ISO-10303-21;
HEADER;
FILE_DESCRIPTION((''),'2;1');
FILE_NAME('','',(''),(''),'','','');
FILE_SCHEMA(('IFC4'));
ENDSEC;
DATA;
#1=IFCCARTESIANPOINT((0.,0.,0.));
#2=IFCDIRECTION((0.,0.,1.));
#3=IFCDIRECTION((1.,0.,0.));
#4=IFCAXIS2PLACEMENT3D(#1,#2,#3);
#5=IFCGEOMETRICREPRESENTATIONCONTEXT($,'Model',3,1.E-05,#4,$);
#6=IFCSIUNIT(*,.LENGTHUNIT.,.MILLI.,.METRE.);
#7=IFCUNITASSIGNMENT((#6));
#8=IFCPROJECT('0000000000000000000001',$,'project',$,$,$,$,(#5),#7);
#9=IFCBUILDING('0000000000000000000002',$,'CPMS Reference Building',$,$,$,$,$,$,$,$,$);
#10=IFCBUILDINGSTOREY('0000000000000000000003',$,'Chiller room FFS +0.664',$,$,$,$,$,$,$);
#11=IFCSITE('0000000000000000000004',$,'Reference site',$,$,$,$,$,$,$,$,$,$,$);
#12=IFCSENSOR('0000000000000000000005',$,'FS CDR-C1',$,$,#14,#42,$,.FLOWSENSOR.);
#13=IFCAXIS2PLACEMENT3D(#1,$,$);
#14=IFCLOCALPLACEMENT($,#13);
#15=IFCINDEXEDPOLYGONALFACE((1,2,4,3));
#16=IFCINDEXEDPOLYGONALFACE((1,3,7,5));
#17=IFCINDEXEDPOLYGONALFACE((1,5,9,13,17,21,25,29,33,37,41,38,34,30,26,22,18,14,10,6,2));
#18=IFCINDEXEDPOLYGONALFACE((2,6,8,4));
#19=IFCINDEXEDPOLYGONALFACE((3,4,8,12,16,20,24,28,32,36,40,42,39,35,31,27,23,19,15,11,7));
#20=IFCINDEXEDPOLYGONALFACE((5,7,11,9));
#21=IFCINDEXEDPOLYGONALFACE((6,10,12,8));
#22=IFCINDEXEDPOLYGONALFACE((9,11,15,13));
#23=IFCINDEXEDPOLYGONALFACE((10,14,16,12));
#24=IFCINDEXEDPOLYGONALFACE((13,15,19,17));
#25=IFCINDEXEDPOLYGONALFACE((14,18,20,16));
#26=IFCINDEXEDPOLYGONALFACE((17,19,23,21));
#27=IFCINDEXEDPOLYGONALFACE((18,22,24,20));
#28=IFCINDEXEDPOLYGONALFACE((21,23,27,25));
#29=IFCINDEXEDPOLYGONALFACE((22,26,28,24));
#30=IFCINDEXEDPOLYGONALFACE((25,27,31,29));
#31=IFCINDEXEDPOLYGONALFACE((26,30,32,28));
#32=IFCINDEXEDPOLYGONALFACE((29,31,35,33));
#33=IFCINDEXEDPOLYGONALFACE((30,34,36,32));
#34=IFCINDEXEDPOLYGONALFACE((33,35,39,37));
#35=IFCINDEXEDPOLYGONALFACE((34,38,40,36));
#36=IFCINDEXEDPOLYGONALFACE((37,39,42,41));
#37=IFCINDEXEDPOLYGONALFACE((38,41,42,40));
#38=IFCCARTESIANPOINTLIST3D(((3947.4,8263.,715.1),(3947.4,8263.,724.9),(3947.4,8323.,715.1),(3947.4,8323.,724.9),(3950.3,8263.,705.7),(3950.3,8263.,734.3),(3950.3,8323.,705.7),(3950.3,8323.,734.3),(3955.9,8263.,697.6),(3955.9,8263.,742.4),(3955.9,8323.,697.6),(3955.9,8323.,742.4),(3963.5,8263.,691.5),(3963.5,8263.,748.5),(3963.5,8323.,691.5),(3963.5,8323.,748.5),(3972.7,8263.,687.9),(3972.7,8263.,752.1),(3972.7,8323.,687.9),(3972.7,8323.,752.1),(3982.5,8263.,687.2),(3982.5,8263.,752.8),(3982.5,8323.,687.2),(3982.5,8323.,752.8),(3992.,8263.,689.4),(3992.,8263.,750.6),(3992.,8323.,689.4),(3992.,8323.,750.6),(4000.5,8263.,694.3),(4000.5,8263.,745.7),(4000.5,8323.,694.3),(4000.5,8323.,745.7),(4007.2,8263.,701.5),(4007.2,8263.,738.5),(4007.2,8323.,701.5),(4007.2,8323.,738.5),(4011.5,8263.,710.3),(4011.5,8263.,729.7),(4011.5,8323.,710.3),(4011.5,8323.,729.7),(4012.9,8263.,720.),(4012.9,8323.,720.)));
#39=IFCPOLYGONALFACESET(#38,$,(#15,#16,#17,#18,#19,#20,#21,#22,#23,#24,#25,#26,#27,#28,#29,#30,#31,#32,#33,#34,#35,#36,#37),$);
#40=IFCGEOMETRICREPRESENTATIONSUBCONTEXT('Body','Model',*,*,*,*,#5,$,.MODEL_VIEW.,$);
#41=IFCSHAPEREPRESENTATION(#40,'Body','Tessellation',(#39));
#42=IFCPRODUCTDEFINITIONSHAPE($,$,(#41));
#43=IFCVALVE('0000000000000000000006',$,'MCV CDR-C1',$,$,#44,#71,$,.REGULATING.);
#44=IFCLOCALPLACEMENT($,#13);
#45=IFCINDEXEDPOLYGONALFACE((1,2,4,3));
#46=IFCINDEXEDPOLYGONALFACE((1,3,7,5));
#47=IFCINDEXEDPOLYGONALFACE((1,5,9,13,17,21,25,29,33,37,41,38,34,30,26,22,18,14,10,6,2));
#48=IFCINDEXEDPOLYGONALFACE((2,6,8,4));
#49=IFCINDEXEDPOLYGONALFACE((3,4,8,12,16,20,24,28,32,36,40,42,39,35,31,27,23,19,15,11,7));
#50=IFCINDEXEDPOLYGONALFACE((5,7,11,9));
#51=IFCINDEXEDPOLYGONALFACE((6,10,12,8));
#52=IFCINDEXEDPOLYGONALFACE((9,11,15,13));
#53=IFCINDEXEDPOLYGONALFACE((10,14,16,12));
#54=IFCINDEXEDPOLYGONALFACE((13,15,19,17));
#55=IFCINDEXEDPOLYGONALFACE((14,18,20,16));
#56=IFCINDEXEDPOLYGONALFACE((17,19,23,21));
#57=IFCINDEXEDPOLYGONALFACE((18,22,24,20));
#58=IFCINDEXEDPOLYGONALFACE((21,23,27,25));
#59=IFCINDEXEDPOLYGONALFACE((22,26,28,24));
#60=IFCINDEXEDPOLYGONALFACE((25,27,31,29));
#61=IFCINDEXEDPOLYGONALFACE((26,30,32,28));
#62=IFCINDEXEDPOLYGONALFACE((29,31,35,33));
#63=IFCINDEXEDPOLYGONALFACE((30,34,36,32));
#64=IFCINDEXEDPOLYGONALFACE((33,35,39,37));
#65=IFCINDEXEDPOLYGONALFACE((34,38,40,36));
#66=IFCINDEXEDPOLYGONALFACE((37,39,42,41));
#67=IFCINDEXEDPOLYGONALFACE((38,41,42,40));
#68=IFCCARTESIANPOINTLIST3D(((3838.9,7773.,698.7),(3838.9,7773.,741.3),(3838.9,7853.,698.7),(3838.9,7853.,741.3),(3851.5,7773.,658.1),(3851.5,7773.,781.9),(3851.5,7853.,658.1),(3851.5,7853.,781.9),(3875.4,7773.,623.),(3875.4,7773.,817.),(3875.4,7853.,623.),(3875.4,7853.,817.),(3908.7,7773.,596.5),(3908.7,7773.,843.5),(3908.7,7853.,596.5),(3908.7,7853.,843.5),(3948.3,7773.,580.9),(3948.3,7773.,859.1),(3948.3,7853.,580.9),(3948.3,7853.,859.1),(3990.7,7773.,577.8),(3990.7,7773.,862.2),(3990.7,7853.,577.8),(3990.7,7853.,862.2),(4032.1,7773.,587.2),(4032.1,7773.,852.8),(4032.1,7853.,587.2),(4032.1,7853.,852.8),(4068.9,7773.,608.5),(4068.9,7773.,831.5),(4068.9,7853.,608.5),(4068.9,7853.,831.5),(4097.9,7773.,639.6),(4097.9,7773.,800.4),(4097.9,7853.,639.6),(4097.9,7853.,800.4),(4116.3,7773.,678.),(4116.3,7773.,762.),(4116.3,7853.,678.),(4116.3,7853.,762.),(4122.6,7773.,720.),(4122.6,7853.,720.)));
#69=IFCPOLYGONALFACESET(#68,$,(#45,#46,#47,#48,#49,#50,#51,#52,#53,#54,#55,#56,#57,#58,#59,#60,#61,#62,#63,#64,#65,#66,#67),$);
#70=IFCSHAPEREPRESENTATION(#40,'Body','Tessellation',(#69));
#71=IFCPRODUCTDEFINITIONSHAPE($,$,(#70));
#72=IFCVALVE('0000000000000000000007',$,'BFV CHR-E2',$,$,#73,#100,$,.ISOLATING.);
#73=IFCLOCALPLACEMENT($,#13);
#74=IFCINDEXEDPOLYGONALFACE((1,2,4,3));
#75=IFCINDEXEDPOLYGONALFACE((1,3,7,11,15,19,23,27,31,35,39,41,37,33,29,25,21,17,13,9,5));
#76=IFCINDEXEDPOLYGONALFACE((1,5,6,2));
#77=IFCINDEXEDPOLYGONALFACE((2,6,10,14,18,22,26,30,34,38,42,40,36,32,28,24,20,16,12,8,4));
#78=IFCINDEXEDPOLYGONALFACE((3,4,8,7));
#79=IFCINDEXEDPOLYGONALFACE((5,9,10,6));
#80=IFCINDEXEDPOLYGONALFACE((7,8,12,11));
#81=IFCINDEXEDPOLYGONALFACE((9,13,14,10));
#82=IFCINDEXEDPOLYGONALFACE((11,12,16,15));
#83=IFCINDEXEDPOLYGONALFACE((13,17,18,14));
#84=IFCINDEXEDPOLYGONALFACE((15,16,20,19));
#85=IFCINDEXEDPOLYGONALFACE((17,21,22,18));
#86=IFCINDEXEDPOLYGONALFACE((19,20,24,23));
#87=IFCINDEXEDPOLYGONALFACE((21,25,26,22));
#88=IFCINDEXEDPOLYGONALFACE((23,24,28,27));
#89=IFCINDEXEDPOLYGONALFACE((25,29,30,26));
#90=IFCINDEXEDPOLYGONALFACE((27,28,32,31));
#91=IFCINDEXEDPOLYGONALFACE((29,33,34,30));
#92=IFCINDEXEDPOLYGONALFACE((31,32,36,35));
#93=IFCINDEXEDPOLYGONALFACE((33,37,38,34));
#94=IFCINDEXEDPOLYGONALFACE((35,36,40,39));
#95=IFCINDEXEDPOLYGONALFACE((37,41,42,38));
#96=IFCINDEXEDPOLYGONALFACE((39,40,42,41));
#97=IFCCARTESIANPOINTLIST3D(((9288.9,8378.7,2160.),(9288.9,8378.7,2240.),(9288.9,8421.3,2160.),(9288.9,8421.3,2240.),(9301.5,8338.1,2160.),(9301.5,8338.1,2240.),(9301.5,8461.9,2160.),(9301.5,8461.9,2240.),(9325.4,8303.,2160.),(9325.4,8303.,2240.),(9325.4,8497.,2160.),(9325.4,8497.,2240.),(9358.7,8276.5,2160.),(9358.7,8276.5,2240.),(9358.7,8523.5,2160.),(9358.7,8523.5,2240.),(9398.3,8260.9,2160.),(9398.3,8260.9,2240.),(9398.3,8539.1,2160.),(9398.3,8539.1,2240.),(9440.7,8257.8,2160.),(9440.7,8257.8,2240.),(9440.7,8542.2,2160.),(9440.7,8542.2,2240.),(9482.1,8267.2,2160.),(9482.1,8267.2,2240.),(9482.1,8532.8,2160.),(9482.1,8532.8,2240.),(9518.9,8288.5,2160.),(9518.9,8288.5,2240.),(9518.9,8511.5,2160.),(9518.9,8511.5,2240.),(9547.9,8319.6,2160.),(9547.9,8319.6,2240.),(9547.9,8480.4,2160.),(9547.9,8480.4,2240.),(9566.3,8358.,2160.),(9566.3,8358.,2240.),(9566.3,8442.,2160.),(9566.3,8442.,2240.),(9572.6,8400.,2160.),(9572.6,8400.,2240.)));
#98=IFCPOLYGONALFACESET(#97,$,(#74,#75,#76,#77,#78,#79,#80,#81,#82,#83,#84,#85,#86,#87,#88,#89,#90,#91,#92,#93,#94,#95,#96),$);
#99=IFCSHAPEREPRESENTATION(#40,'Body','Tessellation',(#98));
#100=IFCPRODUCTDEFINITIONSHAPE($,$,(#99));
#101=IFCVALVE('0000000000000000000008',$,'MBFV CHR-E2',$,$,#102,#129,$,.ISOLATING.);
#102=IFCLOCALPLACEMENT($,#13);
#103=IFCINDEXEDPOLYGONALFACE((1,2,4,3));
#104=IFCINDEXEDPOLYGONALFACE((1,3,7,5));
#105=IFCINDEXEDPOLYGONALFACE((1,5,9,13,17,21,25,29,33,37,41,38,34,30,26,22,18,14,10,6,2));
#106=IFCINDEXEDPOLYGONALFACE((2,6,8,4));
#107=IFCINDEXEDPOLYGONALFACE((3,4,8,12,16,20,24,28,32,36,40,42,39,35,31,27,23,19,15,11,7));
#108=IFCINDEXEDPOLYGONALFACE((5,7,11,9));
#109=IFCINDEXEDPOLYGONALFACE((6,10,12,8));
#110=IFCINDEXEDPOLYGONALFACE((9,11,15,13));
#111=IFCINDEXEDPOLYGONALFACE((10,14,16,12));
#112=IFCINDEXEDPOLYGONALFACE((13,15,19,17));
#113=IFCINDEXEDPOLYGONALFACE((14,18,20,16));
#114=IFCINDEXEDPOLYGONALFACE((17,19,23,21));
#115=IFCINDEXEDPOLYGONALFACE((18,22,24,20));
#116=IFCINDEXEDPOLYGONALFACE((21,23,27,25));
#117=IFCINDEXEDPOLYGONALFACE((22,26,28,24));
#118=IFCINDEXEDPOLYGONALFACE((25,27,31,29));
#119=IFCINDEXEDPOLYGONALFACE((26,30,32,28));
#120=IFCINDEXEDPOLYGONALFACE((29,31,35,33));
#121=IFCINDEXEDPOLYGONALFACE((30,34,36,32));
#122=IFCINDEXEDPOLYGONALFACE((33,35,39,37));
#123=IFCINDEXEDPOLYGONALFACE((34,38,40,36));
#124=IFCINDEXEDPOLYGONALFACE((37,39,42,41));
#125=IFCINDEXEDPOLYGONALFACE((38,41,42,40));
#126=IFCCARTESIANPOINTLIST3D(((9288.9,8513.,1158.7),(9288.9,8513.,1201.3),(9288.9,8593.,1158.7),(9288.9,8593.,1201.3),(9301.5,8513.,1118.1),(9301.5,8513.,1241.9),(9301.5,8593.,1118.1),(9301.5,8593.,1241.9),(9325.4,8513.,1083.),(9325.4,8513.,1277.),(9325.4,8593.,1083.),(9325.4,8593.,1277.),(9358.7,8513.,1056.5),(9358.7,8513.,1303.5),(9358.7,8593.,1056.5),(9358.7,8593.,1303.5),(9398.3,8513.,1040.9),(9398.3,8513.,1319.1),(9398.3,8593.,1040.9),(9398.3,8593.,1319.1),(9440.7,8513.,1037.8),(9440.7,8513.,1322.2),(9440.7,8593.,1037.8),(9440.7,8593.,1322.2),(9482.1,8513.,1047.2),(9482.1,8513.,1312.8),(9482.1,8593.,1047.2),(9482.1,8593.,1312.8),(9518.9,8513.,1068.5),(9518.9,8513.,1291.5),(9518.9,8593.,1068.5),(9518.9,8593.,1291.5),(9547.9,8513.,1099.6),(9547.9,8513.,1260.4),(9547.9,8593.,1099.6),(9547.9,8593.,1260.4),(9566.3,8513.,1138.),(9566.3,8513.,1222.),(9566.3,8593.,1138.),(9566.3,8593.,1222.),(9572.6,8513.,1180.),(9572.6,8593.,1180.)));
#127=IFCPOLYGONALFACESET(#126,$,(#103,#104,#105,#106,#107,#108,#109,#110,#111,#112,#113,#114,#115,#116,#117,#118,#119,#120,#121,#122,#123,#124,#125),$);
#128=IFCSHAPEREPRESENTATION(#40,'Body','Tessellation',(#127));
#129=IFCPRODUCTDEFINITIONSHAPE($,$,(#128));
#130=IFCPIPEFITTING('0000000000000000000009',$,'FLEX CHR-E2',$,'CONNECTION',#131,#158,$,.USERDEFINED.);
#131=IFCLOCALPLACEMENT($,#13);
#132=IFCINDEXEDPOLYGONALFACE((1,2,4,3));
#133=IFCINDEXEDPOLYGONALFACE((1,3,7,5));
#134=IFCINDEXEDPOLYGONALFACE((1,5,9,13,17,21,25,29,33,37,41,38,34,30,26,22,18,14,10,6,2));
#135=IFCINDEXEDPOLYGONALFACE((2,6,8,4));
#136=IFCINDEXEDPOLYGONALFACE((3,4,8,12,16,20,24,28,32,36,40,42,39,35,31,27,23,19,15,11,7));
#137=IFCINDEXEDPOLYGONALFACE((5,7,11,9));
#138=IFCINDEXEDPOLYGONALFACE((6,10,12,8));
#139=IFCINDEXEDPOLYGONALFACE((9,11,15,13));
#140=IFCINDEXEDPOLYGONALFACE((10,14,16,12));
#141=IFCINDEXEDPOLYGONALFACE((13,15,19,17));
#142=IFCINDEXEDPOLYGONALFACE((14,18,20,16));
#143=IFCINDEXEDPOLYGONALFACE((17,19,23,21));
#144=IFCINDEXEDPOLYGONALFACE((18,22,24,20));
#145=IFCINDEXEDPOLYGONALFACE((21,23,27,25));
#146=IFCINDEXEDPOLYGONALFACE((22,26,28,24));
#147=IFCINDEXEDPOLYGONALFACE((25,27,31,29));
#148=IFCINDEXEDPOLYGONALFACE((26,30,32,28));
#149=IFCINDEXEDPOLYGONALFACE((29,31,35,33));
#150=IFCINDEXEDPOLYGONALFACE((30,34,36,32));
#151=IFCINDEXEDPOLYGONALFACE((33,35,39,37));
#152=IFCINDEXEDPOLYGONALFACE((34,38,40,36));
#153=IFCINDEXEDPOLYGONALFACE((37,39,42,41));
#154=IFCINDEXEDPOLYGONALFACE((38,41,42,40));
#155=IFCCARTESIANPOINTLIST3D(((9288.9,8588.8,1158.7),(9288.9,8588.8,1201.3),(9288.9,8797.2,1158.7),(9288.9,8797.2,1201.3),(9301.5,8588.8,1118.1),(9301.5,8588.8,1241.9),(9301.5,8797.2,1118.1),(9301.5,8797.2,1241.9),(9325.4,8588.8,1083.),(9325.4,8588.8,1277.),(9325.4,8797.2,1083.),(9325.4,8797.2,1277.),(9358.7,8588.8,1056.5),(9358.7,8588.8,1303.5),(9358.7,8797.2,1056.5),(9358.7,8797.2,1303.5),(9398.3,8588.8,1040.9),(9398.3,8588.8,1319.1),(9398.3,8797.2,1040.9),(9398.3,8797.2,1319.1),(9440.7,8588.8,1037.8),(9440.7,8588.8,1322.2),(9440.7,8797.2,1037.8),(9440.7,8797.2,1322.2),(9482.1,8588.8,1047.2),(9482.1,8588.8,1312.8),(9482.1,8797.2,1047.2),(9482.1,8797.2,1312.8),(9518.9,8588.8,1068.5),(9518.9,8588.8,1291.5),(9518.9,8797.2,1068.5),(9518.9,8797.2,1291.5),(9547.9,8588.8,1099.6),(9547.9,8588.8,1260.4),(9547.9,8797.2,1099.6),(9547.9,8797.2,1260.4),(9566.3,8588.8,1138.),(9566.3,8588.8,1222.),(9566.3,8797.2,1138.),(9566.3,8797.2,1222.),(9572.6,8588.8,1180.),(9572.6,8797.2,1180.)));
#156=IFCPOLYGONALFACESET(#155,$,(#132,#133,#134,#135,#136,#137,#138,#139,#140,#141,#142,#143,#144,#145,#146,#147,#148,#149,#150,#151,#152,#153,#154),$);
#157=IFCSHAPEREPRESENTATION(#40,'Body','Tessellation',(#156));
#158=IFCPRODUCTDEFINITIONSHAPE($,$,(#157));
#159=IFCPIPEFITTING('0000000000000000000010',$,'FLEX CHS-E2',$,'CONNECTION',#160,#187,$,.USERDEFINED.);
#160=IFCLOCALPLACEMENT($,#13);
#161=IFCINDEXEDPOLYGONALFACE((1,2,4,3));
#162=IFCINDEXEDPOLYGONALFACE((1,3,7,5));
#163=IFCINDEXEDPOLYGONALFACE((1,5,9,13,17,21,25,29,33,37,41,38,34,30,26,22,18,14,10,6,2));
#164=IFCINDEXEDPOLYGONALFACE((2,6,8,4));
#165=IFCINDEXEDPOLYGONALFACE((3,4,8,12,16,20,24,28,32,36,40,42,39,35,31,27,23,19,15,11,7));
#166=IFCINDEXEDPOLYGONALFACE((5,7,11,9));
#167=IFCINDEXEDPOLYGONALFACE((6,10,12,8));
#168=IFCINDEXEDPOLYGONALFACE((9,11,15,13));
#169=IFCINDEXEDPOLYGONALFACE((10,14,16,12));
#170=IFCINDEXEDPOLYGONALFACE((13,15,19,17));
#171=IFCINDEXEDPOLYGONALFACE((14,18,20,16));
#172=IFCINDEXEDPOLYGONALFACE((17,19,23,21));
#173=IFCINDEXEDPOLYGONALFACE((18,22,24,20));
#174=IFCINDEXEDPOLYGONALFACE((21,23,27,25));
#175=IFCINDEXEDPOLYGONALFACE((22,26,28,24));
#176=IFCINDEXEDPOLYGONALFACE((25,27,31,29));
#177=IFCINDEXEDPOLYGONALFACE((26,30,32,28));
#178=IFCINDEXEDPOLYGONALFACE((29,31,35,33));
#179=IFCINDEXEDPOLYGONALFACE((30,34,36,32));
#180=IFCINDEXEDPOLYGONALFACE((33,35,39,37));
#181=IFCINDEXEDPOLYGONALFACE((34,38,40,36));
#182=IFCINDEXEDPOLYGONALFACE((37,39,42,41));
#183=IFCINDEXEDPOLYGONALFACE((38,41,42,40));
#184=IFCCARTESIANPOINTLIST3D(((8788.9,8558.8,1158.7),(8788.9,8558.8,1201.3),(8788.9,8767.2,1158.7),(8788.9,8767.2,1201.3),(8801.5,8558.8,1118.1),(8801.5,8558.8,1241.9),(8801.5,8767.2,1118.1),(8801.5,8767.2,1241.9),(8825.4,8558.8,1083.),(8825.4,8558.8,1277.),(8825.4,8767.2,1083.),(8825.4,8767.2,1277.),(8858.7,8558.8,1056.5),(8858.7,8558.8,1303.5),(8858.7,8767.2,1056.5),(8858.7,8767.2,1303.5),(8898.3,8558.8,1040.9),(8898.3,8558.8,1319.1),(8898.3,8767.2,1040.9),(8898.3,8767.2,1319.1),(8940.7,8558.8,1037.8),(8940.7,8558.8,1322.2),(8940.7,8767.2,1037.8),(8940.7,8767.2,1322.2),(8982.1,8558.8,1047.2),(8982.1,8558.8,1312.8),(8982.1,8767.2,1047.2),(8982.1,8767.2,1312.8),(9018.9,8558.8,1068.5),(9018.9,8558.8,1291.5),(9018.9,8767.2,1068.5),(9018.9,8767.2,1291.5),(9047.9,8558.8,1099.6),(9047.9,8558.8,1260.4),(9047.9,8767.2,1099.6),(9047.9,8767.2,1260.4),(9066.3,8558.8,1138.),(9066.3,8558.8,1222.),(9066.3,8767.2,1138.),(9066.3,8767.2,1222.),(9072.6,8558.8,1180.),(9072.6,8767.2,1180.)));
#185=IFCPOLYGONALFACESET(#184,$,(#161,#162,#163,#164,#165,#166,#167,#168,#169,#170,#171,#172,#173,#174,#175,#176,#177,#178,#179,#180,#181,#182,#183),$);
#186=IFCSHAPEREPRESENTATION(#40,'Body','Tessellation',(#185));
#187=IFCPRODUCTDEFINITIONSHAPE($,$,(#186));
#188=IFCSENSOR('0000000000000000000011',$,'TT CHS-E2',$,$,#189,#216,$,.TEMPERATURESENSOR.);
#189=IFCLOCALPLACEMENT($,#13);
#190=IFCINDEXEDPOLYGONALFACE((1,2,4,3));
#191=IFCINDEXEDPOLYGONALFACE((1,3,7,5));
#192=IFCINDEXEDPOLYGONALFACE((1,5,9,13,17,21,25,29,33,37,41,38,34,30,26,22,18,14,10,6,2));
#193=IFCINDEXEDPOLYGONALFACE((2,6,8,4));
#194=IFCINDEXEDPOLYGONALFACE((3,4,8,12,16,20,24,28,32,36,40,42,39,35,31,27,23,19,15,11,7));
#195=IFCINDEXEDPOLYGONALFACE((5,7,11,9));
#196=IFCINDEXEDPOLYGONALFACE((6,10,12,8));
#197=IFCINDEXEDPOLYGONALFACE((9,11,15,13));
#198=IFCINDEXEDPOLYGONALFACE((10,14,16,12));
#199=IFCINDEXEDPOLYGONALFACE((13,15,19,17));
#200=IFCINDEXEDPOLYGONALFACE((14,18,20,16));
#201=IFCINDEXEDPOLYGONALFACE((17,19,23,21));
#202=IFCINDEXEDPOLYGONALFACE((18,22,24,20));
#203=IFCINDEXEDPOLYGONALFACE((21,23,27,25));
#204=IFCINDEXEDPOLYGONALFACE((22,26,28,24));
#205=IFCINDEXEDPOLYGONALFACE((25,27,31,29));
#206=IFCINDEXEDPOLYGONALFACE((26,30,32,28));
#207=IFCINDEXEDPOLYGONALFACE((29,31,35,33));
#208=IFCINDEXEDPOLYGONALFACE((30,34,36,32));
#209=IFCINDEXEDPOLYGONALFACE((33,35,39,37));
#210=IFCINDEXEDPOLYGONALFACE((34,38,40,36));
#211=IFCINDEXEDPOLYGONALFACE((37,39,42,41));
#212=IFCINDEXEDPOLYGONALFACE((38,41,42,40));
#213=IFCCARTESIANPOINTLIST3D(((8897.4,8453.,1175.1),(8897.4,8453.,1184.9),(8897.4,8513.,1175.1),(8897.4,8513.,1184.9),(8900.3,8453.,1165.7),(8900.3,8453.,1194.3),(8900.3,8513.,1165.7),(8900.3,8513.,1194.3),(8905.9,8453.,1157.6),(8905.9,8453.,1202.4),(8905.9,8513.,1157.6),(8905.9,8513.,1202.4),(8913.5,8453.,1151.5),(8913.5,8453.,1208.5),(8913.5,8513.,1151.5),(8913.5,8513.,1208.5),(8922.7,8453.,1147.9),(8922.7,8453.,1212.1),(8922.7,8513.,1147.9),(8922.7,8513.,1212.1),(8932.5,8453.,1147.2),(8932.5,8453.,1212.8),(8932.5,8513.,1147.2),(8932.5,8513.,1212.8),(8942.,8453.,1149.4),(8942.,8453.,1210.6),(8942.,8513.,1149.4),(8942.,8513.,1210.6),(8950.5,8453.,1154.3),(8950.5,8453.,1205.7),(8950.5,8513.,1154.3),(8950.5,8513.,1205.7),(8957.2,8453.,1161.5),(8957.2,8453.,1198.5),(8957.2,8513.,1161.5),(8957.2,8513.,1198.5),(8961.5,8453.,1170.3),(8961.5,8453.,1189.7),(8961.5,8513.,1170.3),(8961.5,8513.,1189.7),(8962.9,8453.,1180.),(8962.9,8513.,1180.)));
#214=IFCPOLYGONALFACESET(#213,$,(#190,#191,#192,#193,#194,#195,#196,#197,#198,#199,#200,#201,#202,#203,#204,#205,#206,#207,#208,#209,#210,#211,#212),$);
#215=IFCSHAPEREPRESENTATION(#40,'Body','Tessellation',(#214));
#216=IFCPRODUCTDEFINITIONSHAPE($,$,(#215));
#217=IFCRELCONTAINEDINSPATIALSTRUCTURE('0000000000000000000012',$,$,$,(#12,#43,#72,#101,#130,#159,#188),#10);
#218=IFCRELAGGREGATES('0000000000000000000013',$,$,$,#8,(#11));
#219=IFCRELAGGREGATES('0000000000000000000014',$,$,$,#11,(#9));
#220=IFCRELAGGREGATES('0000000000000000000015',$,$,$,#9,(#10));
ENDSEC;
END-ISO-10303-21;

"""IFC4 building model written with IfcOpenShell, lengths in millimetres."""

from ifc_helpers import new_model, si_unit, frame, origin_with_axes, origin_2d, place, context, subcontext, project, spatial, circle_curve, outline, extrude, element, save


model = new_model("IFC4")

# Units and contexts
model_context = context("Model", 3, precision=1e-05, world=origin_with_axes())
body_context = subcontext(model_context, "Body", "Model", "MODEL_VIEW")
ifc_project = project(units=[si_unit("LENGTHUNIT", "METRE", prefix="MILLI")], contexts=[model_context])

# Site, building, storey
site = spatial("IfcSite", under=ifc_project, Name="Reference site")
building = spatial("IfcBuilding", under=site, Name="CPMS Reference Building")
storey = spatial("IfcBuildingStorey", under=building, Name="Chiller room FFS +0.664")

# Sensor
sensor_1_placement = place(None, origin_with_axes())
element("IfcSensor", 1, at=sensor_1_placement, inside=storey, Name="FS CDR-C1", PredefinedType="FLOWSENSOR", context=body_context, shape_type="SweptSolid", body=[
    extrude(outline(circle_curve(origin_2d(), 32.9)), frame((3980.0, 8323.0, 720.0), z_axis=(0.0, -1.0, 0.0), x_axis=(1.0, 0.0, 0.0)), (0.0, 0.0, 1.0), 60.0),
])

# Valves
valve_1_placement = place(None, origin_with_axes())
element("IfcValve", 2, at=valve_1_placement, inside=storey, Name="MCV CDR-C1", PredefinedType="REGULATING", context=body_context, shape_type="SweptSolid", body=[
    extrude(outline(circle_curve(origin_2d(), 142.6)), frame((3980.0, 7853.0, 720.0), z_axis=(0.0, -1.0, 0.0), x_axis=(1.0, 0.0, 0.0)), (0.0, 0.0, 1.0), 80.0),
])
valve_2_placement = place(None, origin_with_axes())
element("IfcValve", 3, at=valve_2_placement, inside=storey, Name="BFV CHR-E2", PredefinedType="ISOLATING", context=body_context, shape_type="SweptSolid", body=[
    extrude(outline(circle_curve(origin_2d(), 142.6)), frame((9430.0, 8400.0, 2240.0), z_axis=(0.0, 0.0, -1.0), x_axis=(1.0, 0.0, 0.0)), (0.0, 0.0, 1.0), 80.0),
])
valve_3_placement = place(None, origin_with_axes())
element("IfcValve", 4, at=valve_3_placement, inside=storey, Name="MBFV CHR-E2", PredefinedType="ISOLATING", context=body_context, shape_type="SweptSolid", body=[
    extrude(outline(circle_curve(origin_2d(), 142.6)), frame((9430.0, 8513.0, 1180.0), z_axis=(0.0, 1.0, 0.0), x_axis=(1.0, 0.0, 0.0)), (0.0, 0.0, 1.0), 80.0),
])

# Pipe fittings
pipe_fitting_1_placement = place(None, origin_with_axes())
element("IfcPipeFitting", 5, at=pipe_fitting_1_placement, inside=storey, Name="FLEX CHR-E2", ObjectType="CONNECTION", PredefinedType="USERDEFINED", context=body_context, shape_type="SweptSolid", body=[
    extrude(outline(circle_curve(origin_2d(), 142.6)), frame((9430.0, 8588.8, 1180.0), z_axis=(0.0, 1.0, 0.0), x_axis=(1.0, 0.0, 0.0)), (0.0, 0.0, 1.0), 208.5),
])
pipe_fitting_2_placement = place(None, origin_with_axes())
element("IfcPipeFitting", 6, at=pipe_fitting_2_placement, inside=storey, Name="FLEX CHS-E2", ObjectType="CONNECTION", PredefinedType="USERDEFINED", context=body_context, shape_type="SweptSolid", body=[
    extrude(outline(circle_curve(origin_2d(), 142.6)), frame((8930.0, 8767.2, 1180.0), z_axis=(0.0, -1.0, 0.0), x_axis=(1.0, 0.0, 0.0)), (0.0, 0.0, 1.0), 208.5),
])

# Sensor
sensor_2_placement = place(None, origin_with_axes())
element("IfcSensor", 7, at=sensor_2_placement, inside=storey, Name="TT CHS-E2", PredefinedType="TEMPERATURESENSOR", context=body_context, shape_type="SweptSolid", body=[
    extrude(outline(circle_curve(origin_2d(), 32.9)), frame((8930.0, 8513.0, 1180.0), z_axis=(0.0, -1.0, 0.0), x_axis=(1.0, 0.0, 0.0)), (0.0, 0.0, 1.0), 60.0),
])

save(model, "model.ifc")
